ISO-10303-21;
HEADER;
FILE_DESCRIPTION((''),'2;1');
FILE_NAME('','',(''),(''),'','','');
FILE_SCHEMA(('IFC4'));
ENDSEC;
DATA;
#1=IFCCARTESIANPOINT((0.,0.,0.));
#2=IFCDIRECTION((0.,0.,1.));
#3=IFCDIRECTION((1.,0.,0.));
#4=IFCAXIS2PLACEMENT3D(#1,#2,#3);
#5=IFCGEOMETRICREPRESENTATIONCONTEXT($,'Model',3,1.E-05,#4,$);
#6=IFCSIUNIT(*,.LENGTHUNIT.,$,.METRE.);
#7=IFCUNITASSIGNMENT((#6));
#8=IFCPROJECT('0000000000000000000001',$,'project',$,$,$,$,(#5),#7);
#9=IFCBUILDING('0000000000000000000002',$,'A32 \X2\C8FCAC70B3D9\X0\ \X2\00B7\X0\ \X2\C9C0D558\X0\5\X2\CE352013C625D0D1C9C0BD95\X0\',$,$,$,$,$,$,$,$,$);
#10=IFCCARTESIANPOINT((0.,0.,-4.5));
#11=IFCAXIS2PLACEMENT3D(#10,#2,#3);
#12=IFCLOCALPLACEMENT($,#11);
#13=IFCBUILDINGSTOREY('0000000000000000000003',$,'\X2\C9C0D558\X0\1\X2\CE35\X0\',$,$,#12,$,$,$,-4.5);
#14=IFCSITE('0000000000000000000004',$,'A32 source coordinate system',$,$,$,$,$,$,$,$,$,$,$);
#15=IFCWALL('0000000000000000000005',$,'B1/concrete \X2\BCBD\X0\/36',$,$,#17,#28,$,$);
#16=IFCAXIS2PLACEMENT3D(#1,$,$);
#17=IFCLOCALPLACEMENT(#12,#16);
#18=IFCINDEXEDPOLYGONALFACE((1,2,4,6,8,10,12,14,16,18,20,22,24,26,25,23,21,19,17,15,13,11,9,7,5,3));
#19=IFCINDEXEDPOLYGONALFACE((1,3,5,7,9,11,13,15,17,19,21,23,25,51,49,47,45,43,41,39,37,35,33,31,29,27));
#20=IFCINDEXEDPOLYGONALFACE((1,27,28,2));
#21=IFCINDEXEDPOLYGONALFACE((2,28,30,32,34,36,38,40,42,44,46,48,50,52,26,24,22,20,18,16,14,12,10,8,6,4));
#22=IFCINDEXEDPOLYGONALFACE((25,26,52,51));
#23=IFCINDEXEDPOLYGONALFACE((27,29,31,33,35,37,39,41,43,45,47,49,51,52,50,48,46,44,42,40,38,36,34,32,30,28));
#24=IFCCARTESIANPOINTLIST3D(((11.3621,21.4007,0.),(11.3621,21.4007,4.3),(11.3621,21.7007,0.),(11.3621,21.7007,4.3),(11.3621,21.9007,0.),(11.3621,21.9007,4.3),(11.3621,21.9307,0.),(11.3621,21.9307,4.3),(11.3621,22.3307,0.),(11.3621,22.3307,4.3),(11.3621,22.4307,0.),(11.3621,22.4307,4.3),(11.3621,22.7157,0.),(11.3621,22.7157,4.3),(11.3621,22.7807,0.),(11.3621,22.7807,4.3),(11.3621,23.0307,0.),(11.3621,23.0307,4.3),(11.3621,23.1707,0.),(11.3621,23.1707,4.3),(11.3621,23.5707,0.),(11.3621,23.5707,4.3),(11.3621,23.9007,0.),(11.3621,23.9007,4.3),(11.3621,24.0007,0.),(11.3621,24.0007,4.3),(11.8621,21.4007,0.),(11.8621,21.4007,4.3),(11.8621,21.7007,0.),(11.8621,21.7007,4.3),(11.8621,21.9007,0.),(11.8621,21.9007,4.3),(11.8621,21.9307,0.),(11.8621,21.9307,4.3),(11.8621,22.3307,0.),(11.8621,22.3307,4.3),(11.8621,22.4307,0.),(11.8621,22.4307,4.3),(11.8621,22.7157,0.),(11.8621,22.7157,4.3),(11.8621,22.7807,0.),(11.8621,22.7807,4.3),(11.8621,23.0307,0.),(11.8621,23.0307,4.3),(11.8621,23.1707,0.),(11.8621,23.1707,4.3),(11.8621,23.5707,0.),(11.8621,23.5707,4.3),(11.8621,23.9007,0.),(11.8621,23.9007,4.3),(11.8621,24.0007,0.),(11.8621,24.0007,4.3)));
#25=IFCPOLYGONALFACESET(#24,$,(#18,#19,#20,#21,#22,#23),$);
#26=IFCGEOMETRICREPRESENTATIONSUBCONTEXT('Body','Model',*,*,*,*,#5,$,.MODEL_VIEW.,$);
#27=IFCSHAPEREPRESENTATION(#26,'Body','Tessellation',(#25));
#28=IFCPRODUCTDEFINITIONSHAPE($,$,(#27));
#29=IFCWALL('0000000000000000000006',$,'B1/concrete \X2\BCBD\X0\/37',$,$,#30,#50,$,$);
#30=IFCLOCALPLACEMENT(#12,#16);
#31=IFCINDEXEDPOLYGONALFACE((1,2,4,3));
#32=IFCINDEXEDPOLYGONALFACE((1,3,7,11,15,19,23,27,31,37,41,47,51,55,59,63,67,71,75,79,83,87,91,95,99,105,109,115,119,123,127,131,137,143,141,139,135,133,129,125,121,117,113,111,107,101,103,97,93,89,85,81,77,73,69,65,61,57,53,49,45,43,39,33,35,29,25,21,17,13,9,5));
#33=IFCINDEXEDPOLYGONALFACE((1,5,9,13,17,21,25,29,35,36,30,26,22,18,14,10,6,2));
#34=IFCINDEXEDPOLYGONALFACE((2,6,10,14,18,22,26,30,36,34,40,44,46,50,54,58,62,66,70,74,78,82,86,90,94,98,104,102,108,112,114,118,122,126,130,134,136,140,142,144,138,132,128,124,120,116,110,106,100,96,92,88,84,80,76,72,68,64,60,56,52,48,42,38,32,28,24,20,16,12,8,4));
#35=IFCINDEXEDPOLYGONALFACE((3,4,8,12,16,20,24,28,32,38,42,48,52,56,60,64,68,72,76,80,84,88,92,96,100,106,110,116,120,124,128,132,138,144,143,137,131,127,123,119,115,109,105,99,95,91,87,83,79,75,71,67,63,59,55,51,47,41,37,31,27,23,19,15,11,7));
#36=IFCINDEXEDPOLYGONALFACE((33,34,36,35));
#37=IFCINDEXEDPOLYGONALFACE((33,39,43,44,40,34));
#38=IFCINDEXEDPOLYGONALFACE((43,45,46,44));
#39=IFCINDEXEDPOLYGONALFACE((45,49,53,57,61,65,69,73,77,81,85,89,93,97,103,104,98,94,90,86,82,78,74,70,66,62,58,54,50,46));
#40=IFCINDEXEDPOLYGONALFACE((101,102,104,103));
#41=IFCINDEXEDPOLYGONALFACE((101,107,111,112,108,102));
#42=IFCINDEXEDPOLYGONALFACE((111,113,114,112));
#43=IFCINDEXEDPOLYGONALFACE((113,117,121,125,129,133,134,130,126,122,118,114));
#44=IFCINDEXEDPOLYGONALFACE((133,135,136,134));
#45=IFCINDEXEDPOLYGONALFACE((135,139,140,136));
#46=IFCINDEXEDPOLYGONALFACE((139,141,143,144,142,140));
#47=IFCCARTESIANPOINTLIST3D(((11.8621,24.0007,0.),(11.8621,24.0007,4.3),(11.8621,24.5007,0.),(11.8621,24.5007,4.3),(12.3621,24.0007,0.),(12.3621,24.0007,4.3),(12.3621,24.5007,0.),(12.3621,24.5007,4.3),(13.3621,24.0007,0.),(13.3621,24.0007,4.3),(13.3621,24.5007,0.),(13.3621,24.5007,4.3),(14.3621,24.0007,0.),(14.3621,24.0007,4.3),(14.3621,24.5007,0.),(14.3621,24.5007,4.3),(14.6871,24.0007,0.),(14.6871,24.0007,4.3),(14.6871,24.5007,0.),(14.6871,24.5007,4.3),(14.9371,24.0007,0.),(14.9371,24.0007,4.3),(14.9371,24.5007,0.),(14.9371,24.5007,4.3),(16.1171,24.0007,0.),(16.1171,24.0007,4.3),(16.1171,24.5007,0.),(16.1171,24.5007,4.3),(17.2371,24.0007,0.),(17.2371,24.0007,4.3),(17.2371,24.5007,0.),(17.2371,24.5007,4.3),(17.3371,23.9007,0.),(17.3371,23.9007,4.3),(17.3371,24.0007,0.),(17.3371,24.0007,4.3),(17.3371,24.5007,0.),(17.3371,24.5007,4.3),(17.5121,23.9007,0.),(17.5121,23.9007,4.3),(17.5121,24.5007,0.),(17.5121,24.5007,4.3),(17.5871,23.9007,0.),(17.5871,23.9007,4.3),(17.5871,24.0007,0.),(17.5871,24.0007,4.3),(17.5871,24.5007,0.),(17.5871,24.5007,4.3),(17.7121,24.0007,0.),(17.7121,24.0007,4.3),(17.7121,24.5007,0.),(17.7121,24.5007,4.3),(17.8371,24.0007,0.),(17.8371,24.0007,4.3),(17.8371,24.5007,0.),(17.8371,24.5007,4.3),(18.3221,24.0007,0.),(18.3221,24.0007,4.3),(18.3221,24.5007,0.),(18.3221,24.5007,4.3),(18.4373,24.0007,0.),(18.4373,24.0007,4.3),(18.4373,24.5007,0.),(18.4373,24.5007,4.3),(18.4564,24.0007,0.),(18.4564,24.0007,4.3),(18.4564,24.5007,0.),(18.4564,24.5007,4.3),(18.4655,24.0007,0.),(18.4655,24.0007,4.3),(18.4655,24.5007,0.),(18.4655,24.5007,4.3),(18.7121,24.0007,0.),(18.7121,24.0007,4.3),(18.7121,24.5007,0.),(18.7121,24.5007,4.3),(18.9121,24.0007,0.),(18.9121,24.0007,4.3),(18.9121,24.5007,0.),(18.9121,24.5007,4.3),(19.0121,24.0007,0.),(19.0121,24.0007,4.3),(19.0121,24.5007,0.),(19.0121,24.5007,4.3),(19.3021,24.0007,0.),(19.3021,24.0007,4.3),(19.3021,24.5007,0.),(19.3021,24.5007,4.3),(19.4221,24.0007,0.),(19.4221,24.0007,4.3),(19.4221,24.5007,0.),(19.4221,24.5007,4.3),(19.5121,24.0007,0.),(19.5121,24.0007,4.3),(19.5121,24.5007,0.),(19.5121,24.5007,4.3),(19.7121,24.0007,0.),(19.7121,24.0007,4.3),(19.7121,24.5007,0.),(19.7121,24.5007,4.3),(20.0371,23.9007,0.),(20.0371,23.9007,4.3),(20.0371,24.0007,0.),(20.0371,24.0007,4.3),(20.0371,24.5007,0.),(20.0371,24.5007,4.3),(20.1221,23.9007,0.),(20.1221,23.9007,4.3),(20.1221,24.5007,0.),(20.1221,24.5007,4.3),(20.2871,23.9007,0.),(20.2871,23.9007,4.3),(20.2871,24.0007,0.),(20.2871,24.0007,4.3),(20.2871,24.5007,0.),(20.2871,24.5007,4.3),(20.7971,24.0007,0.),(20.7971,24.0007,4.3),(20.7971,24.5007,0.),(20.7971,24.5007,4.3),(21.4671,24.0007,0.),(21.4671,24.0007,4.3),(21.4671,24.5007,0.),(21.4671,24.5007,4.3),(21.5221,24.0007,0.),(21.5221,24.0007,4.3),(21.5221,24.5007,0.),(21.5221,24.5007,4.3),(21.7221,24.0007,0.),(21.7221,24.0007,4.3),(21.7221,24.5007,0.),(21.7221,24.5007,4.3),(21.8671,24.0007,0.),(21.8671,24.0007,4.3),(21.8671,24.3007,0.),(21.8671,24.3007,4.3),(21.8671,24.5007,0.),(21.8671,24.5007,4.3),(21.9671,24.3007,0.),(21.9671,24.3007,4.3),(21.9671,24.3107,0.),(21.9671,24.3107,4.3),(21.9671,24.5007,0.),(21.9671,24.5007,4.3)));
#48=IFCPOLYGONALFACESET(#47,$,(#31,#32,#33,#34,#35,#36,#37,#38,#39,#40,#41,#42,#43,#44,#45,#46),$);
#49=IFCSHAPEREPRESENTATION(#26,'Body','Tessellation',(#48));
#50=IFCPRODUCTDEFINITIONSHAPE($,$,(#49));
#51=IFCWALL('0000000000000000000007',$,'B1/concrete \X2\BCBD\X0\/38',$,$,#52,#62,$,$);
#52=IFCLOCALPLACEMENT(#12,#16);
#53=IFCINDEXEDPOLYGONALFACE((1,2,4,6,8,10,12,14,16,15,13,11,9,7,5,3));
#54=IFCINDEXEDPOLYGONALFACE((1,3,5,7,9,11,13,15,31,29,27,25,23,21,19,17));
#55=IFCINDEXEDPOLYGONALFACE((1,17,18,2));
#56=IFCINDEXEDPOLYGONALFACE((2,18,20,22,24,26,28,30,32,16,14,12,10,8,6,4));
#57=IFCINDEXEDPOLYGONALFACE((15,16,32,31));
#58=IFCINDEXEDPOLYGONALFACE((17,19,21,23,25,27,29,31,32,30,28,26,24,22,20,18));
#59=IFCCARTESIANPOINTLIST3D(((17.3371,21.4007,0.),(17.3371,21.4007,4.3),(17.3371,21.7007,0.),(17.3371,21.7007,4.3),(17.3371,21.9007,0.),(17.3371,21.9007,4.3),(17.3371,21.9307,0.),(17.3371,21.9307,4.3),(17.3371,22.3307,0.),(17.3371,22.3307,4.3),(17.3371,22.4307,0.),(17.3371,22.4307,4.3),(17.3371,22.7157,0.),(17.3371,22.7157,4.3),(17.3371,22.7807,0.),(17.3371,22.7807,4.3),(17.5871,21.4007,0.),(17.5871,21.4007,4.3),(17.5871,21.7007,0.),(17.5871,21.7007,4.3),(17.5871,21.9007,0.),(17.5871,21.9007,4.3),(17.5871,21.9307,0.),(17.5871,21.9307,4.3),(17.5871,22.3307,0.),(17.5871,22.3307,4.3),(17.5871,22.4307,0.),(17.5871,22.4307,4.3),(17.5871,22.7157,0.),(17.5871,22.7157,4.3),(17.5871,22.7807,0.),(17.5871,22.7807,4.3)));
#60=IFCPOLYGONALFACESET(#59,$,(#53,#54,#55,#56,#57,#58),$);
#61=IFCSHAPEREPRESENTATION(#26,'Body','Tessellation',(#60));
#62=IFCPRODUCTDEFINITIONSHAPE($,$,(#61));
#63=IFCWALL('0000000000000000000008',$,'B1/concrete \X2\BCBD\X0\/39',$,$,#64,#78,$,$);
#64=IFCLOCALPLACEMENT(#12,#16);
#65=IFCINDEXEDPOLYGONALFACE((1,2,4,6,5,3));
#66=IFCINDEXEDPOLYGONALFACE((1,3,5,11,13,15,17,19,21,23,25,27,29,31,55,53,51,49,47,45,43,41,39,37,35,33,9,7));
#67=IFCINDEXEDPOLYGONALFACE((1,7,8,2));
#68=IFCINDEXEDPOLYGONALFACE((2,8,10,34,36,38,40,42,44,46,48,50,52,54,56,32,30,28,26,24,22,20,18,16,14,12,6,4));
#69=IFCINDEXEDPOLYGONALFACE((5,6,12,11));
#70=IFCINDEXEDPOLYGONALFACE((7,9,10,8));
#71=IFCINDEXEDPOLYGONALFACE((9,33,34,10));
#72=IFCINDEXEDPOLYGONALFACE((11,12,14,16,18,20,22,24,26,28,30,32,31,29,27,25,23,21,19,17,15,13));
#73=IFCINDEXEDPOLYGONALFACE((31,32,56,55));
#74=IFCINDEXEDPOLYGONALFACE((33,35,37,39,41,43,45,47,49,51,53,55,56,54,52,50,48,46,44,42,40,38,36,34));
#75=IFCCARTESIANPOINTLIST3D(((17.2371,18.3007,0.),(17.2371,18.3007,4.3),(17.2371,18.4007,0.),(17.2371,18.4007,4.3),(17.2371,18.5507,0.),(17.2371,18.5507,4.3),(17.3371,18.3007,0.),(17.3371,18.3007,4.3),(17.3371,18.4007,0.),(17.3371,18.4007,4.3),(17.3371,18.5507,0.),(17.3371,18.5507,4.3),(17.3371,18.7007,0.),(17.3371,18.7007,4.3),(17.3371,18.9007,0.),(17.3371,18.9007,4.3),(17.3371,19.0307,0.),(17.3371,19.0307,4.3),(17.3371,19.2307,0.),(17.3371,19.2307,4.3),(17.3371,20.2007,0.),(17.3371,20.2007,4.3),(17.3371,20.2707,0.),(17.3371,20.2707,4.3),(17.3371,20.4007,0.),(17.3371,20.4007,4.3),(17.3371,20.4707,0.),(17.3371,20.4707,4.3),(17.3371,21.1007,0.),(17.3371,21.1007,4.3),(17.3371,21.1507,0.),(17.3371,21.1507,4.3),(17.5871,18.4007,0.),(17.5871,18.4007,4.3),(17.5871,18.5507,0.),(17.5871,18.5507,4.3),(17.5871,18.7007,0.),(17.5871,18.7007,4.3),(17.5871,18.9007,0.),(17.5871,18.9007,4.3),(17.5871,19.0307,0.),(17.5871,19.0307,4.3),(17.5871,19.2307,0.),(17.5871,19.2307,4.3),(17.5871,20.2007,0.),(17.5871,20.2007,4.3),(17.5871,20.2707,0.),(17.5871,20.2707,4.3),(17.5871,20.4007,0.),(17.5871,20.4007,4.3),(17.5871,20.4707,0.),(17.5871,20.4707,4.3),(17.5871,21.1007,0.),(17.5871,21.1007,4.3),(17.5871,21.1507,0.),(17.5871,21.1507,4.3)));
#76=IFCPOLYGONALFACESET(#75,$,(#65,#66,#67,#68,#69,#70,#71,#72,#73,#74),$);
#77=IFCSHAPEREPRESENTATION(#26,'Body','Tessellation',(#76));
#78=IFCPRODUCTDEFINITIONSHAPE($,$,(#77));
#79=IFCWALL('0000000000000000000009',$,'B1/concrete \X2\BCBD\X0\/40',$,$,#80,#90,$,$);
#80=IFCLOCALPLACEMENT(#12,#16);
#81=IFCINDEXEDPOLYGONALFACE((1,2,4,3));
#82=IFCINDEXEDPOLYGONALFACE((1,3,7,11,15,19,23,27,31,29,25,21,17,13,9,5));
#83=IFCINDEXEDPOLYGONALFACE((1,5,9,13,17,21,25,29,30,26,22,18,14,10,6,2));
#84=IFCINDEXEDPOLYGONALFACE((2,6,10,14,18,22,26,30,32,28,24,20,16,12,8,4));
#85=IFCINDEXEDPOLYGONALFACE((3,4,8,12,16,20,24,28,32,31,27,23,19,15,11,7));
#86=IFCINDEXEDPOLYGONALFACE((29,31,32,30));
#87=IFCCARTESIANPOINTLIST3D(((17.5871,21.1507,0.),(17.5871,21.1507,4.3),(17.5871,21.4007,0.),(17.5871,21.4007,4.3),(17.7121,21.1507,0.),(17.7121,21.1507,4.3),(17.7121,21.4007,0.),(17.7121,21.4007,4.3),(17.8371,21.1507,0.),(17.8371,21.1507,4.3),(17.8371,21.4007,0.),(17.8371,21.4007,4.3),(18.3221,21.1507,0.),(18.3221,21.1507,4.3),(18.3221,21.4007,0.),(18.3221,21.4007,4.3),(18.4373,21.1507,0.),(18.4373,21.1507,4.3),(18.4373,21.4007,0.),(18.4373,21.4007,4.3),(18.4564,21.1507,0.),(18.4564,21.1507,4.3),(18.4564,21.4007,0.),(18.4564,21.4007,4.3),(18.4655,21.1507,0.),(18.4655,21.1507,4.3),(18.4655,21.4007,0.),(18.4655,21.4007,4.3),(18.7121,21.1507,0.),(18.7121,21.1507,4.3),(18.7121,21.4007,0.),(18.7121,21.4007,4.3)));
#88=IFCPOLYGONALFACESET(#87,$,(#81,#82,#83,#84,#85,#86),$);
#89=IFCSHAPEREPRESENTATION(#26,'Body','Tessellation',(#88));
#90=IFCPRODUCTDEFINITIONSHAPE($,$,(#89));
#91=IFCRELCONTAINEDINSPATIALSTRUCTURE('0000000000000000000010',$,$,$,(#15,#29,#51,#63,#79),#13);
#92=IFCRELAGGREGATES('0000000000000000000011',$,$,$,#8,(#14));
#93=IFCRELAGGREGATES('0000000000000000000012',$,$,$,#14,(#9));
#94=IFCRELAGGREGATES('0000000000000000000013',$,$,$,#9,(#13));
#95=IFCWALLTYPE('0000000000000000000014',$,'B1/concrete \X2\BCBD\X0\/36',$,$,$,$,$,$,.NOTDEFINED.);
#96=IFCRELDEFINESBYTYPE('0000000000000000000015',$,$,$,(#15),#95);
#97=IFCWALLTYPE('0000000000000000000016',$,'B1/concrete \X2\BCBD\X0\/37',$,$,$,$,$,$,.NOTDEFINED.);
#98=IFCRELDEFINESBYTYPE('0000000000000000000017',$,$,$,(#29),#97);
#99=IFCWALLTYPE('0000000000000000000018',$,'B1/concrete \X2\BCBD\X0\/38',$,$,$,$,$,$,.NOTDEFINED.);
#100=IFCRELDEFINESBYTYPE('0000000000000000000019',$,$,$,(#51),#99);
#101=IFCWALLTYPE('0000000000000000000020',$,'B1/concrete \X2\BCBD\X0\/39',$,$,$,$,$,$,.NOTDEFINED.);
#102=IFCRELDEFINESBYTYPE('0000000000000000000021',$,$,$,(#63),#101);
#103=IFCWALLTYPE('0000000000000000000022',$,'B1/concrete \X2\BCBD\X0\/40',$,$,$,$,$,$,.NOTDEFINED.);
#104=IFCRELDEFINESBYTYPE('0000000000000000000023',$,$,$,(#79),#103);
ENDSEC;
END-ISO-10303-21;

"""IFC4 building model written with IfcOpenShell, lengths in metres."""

from ifc_helpers import new_model, si_unit, frame, origin, origin_with_axes, place, context, subcontext, project, spatial, polyline, outline, extrude, source, transform, mapped, type_object, type_shapes, element, save


model = new_model("IFC4")

# Units and contexts
model_context = context("Model", 3, precision=1e-05, world=origin_with_axes())
body_context = subcontext(model_context, "Body", "Model", "MODEL_VIEW")
ifc_project = project(units=[si_unit("LENGTHUNIT", "METRE")], contexts=[model_context])

# Site, building, storey
site = spatial("IfcSite", under=ifc_project, Name="A32 source coordinate system")
building = spatial("IfcBuilding", under=site, Name="A32 주거동 · 지하5층–옥탑지붕")
storey_placement = place(None, frame((0.0, 0.0, -4.5), z_axis=(0.0, 0.0, 1.0), x_axis=(1.0, 0.0, 0.0)))
storey = spatial("IfcBuildingStorey", under=building, at=storey_placement, Name="지하1층", Elevation=-4.5)

# Walls
wall_type_1 = type_object("IfcWallType", Name="B1/concrete 벽/36", PredefinedType="NOTDEFINED")
shared_shape_1 = source(origin(), body_context, "Body", "SweptSolid", [
    extrude(outline(polyline([(11.3621, 21.9007), (11.3621, 21.9307), (11.3621, 22.3307), (11.3621, 22.4307), (11.3621, 22.7157), (11.3621, 22.7807), (11.3621, 23.0307), (11.3621, 23.1707), (11.3621, 23.5707), (11.3621, 23.9007), (11.3621, 24.0007), (11.8621, 24.0007), (11.8621, 23.9007), (11.8621, 23.5707), (11.8621, 23.1707), (11.8621, 23.0307), (11.8621, 22.7807), (11.8621, 22.7157), (11.8621, 22.4307), (11.8621, 22.3307), (11.8621, 21.9307), (11.8621, 21.9007), (11.8621, 21.7007), (11.8621, 21.4007), (11.3621, 21.4007), (11.3621, 21.7007), (11.3621, 21.9007)])), origin(), (0.0, 0.0, 1.0), 4.3),
])
type_shapes(wall_type_1, [shared_shape_1])
wall_1_placement = place(storey_placement, origin_with_axes())
element("IfcWall", 1, at=wall_1_placement, inside=storey, type_object=wall_type_1, Name="B1/concrete 벽/36", context=body_context, shape_type="MappedRepresentation", body=[
    mapped(shared_shape_1, transform((0.0, 0.0, 0.0), scale=1.0)),
])
wall_type_2 = type_object("IfcWallType", Name="B1/concrete 벽/37", PredefinedType="NOTDEFINED")
shared_shape_2 = source(origin(), body_context, "Body", "SweptSolid", [
    extrude(outline(polyline([(13.3621, 24.5007), (14.3621, 24.5007), (14.6871, 24.5007), (14.9371, 24.5007), (16.1171, 24.5007), (17.2371, 24.5007), (17.3371, 24.5007), (17.5121, 24.5007), (17.5871, 24.5007), (17.7121, 24.5007), (17.8371, 24.5007), (18.3221, 24.5007), (18.4373, 24.5007), (18.4564, 24.5007), (18.4655, 24.5007), (18.7121, 24.5007), (18.9121, 24.5007), (19.0121, 24.5007), (19.3021, 24.5007), (19.4221, 24.5007), (19.5121, 24.5007), (19.7121, 24.5007), (20.0371, 24.5007), (20.1221, 24.5007), (20.2871, 24.5007), (20.7971, 24.5007), (21.4671, 24.5007), (21.5221, 24.5007), (21.7221, 24.5007), (21.8671, 24.5007), (21.9671, 24.5007), (21.9671, 24.3107), (21.9671, 24.3007), (21.8671, 24.3007), (21.8671, 24.0007), (21.7221, 24.0007), (21.5221, 24.0007), (21.4671, 24.0007), (20.7971, 24.0007), (20.2871, 24.0007), (20.2871, 23.9007), (20.1221, 23.9007), (20.0371, 23.9007), (20.0371, 24.0007), (19.7121, 24.0007), (19.5121, 24.0007), (19.4221, 24.0007), (19.3021, 24.0007), (19.0121, 24.0007), (18.9121, 24.0007), (18.7121, 24.0007), (18.4655, 24.0007), (18.4564, 24.0007), (18.4373, 24.0007), (18.3221, 24.0007), (17.8371, 24.0007), (17.7121, 24.0007), (17.5871, 24.0007), (17.5871, 23.9007), (17.5121, 23.9007), (17.3371, 23.9007), (17.3371, 24.0007), (17.2371, 24.0007), (16.1171, 24.0007), (14.9371, 24.0007), (14.6871, 24.0007), (14.3621, 24.0007), (13.3621, 24.0007), (12.3621, 24.0007), (11.8621, 24.0007), (11.8621, 24.5007), (12.3621, 24.5007), (13.3621, 24.5007)])), origin(), (0.0, 0.0, 1.0), 4.3),
])
type_shapes(wall_type_2, [shared_shape_2])
wall_2_placement = place(storey_placement, origin_with_axes())
element("IfcWall", 2, at=wall_2_placement, inside=storey, type_object=wall_type_2, Name="B1/concrete 벽/37", context=body_context, shape_type="MappedRepresentation", body=[
    mapped(shared_shape_2, transform((0.0, 0.0, 0.0), scale=1.0)),
])
wall_type_3 = type_object("IfcWallType", Name="B1/concrete 벽/38", PredefinedType="NOTDEFINED")
shared_shape_3 = source(origin(), body_context, "Body", "SweptSolid", [
    extrude(outline(polyline([(17.3371, 21.9307), (17.3371, 22.3307), (17.3371, 22.4307), (17.3371, 22.7157), (17.3371, 22.7807), (17.5871, 22.7807), (17.5871, 22.7157), (17.5871, 22.4307), (17.5871, 22.3307), (17.5871, 21.9307), (17.5871, 21.9007), (17.5871, 21.7007), (17.5871, 21.4007), (17.3371, 21.4007), (17.3371, 21.7007), (17.3371, 21.9007), (17.3371, 21.9307)])), origin(), (0.0, 0.0, 1.0), 4.3),
])
type_shapes(wall_type_3, [shared_shape_3])
wall_3_placement = place(storey_placement, origin_with_axes())
element("IfcWall", 3, at=wall_3_placement, inside=storey, type_object=wall_type_3, Name="B1/concrete 벽/38", context=body_context, shape_type="MappedRepresentation", body=[
    mapped(shared_shape_3, transform((0.0, 0.0, 0.0), scale=1.0)),
])
wall_type_4 = type_object("IfcWallType", Name="B1/concrete 벽/39", PredefinedType="NOTDEFINED")
shared_shape_4 = source(origin(), body_context, "Body", "SweptSolid", [
    extrude(outline(polyline([(17.5871, 20.4707), (17.5871, 20.4007), (17.5871, 20.2707), (17.5871, 20.2007), (17.5871, 19.2307), (17.5871, 19.0307), (17.5871, 18.9007), (17.5871, 18.7007), (17.5871, 18.5507), (17.5871, 18.4007), (17.3371, 18.4007), (17.3371, 18.3007), (17.2371, 18.3007), (17.2371, 18.4007), (17.2371, 18.5507), (17.3371, 18.5507), (17.3371, 18.7007), (17.3371, 18.9007), (17.3371, 19.0307), (17.3371, 19.2307), (17.3371, 20.2007), (17.3371, 20.2707), (17.3371, 20.4007), (17.3371, 20.4707), (17.3371, 21.1007), (17.3371, 21.1507), (17.5871, 21.1507), (17.5871, 21.1007), (17.5871, 20.4707)])), origin(), (0.0, 0.0, 1.0), 4.3),
])
type_shapes(wall_type_4, [shared_shape_4])
wall_4_placement = place(storey_placement, origin_with_axes())
element("IfcWall", 4, at=wall_4_placement, inside=storey, type_object=wall_type_4, Name="B1/concrete 벽/39", context=body_context, shape_type="MappedRepresentation", body=[
    mapped(shared_shape_4, transform((0.0, 0.0, 0.0), scale=1.0)),
])
wall_type_5 = type_object("IfcWallType", Name="B1/concrete 벽/40", PredefinedType="NOTDEFINED")
shared_shape_5 = source(origin(), body_context, "Body", "SweptSolid", [
    extrude(outline(polyline([(17.8371, 21.4007), (18.3221, 21.4007), (18.4373, 21.4007), (18.4564, 21.4007), (18.4655, 21.4007), (18.7121, 21.4007), (18.7121, 21.1507), (18.4655, 21.1507), (18.4564, 21.1507), (18.4373, 21.1507), (18.3221, 21.1507), (17.8371, 21.1507), (17.7121, 21.1507), (17.5871, 21.1507), (17.5871, 21.4007), (17.7121, 21.4007), (17.8371, 21.4007)])), origin(), (0.0, 0.0, 1.0), 4.3),
])
type_shapes(wall_type_5, [shared_shape_5])
wall_5_placement = place(storey_placement, origin_with_axes())
element("IfcWall", 5, at=wall_5_placement, inside=storey, type_object=wall_type_5, Name="B1/concrete 벽/40", context=body_context, shape_type="MappedRepresentation", body=[
    mapped(shared_shape_5, transform((0.0, 0.0, 0.0), scale=1.0)),
])

save(model, "model.ifc")
